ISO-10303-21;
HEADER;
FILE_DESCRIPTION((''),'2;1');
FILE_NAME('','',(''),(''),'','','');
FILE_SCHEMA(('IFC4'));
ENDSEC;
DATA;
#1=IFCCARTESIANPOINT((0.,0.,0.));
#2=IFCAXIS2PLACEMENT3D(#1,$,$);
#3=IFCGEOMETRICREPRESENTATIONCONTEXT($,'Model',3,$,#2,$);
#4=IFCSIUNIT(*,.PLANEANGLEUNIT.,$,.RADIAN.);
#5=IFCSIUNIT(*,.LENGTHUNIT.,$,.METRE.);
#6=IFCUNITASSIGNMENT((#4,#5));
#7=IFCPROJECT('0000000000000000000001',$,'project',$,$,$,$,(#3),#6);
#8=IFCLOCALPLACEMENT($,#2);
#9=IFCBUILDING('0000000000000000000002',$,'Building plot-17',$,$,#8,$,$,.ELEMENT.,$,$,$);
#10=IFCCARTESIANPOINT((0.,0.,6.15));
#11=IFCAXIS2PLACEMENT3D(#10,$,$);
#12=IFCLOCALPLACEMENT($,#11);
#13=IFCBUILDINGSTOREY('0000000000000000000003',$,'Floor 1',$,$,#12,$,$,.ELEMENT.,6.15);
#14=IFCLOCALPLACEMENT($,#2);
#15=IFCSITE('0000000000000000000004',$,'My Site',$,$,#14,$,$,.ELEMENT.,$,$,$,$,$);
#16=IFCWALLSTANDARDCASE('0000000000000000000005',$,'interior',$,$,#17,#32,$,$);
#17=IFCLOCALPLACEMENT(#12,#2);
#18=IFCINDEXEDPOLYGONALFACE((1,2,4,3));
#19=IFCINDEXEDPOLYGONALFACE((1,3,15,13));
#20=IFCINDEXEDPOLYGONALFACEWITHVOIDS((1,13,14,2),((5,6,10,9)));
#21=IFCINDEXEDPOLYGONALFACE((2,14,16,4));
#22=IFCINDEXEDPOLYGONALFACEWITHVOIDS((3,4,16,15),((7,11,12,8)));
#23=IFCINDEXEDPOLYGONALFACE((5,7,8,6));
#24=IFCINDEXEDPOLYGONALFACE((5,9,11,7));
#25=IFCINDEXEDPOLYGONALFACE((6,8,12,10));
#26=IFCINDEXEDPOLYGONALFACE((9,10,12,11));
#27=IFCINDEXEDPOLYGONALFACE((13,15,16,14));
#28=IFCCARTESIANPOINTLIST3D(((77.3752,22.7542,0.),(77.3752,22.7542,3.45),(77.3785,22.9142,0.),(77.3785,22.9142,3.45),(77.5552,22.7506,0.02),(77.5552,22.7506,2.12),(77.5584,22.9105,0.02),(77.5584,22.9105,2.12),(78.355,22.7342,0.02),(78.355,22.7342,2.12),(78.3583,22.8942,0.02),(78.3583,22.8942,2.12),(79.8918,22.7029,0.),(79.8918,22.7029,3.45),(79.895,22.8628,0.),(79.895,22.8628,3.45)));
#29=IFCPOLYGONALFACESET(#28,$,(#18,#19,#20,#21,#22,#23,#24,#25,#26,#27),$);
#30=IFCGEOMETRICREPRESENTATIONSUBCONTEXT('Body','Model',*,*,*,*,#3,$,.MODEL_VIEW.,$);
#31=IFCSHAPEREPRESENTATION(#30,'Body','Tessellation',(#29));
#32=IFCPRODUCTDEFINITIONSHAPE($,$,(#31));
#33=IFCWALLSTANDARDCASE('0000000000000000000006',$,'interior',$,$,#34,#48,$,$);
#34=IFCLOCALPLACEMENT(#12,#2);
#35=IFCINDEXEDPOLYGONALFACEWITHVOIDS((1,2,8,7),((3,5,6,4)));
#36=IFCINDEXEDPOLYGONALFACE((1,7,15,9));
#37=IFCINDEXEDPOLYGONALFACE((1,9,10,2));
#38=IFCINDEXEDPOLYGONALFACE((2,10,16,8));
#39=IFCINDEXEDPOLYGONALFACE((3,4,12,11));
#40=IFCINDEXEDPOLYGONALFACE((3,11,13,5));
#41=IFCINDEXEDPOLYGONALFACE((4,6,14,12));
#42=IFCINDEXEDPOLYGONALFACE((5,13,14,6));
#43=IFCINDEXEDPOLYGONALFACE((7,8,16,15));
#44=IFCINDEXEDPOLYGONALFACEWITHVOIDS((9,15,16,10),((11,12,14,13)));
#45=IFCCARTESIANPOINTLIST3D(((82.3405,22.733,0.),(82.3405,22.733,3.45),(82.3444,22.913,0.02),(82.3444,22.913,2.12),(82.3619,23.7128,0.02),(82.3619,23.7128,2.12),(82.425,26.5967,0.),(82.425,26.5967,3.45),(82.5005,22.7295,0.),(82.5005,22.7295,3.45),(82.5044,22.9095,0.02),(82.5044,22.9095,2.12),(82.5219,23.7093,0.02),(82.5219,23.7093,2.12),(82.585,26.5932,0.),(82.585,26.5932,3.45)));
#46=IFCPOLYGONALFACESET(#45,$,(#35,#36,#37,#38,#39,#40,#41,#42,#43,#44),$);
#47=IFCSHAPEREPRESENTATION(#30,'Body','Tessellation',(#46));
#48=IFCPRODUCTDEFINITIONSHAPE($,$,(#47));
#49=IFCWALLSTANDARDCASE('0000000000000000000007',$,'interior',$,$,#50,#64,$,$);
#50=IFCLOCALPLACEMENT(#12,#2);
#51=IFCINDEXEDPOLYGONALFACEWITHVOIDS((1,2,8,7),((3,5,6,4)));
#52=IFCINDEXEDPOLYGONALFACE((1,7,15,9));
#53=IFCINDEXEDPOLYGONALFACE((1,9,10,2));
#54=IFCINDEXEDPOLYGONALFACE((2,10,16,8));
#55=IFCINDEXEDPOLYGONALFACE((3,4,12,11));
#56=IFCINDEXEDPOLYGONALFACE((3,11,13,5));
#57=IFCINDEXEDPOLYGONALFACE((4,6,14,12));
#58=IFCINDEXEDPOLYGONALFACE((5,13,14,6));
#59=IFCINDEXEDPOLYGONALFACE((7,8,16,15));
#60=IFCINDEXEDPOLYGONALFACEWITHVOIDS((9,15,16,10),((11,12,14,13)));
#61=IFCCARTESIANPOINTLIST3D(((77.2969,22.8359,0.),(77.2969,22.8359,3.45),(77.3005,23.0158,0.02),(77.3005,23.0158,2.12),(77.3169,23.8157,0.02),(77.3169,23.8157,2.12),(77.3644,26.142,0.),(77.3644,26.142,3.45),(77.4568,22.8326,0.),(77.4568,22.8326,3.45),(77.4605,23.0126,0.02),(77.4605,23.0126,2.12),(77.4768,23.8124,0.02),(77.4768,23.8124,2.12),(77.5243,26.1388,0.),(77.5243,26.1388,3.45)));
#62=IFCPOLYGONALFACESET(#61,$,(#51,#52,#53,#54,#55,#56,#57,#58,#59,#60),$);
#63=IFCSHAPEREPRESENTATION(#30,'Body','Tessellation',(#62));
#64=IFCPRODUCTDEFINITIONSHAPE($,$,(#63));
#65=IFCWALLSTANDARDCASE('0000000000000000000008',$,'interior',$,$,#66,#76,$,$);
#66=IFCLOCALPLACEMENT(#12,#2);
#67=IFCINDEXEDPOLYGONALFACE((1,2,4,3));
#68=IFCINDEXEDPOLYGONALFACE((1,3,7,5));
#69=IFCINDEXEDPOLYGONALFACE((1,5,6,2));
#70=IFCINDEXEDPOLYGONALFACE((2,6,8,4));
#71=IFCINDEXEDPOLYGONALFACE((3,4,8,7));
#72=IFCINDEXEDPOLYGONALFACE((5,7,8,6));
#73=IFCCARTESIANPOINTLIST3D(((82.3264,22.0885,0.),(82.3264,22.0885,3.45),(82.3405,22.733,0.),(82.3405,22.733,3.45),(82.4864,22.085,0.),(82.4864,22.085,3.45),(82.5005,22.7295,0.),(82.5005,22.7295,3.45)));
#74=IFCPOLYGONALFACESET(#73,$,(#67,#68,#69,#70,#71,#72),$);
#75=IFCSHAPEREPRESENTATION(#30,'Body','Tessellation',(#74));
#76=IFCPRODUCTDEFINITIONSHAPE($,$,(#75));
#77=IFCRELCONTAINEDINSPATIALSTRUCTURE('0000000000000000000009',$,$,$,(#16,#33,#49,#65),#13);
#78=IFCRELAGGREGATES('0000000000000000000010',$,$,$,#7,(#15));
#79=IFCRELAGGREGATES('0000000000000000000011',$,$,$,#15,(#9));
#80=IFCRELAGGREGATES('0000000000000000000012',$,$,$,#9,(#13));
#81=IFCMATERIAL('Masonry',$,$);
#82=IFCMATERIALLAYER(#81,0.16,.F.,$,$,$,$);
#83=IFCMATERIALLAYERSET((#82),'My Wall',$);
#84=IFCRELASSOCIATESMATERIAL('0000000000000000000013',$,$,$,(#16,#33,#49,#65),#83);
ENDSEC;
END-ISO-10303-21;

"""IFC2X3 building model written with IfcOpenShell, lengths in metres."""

from ifc_helpers import new_model, si_unit, frame, origin, place, context, subcontext, project, spatial, polyline, outline, extrude, material, layer, layer_set, layer_usage, element, save


model = new_model("IFC2X3")

# Units and contexts
model_context = context("Model", 3, world=origin())
body_context = subcontext(model_context, "Body", "Model", "MODEL_VIEW")
ifc_project = project(units=[si_unit("PLANEANGLEUNIT", "RADIAN"), si_unit("LENGTHUNIT", "METRE")], contexts=[model_context])

# Site, building, storey
site_placement = place(None, origin())
site = spatial("IfcSite", under=ifc_project, at=site_placement, Name="My Site", CompositionType="ELEMENT")
building_placement = place(None, origin())
building = spatial("IfcBuilding", under=site, at=building_placement, Name="Building plot-17", CompositionType="ELEMENT")
storey_placement = place(None, frame((0.0, 0.0, 6.15)))
storey = spatial("IfcBuildingStorey", under=building, at=storey_placement, Name="Floor 1", CompositionType="ELEMENT", Elevation=6.15)

# Walls, openings
ifc_material_1 = material(Name="Masonry")
ifc_layer_1 = layer(ifc_material_1, 0.16, ventilated=False)
ifc_layer_set_1 = layer_set([ifc_layer_1], Name="My Wall")
ifc_layer_usage_1 = layer_usage(ifc_layer_set_1, "AXIS2", "NEGATIVE", 0.08)
wall_1_placement = place(storey_placement, origin())
wall_1 = element("IfcWallStandardCase", 1, at=wall_1_placement, inside=storey, material=ifc_layer_usage_1, Name="interior", context=body_context, shape_type="SweptSolid", body=[
    extrude(outline(polyline([(77.3785, 22.9142), (77.3752, 22.7542), (79.8918, 22.7029), (79.895, 22.8628), (77.3785, 22.9142)])), origin(), (0.0, 0.0, 1.0), 3.45),
])
opening_1_placement = place(storey_placement, frame((0.0, 0.0, 0.02)))
element("IfcOpeningElement", 2, at=opening_1_placement, cuts=wall_1, ObjectType="Opening", context=body_context, shape_type="SweptSolid", body=[
    extrude(outline(polyline([(77.5552, 22.7506), (78.355, 22.7342), (78.3583, 22.8942), (77.5584, 22.9105), (77.5552, 22.7506)])), origin(), (0.0, 0.0, 1.0), 2.1),
])
wall_2_placement = place(storey_placement, origin())
wall_2 = element("IfcWallStandardCase", 3, at=wall_2_placement, inside=storey, material=ifc_layer_usage_1, Name="interior", context=body_context, shape_type="SweptSolid", body=[
    extrude(outline(polyline([(82.585, 26.5932), (82.425, 26.5967), (82.3405, 22.733), (82.5005, 22.7295), (82.585, 26.5932)])), origin(), (0.0, 0.0, 1.0), 3.45),
])
opening_2_placement = place(storey_placement, frame((0.0, 0.0, 0.02)))
element("IfcOpeningElement", 4, at=opening_2_placement, cuts=wall_2, ObjectType="Opening", context=body_context, shape_type="SweptSolid", body=[
    extrude(outline(polyline([(82.3619, 23.7128), (82.3444, 22.913), (82.5044, 22.9095), (82.5219, 23.7093), (82.3619, 23.7128)])), origin(), (0.0, 0.0, 1.0), 2.1),
])
wall_3_placement = place(storey_placement, origin())
wall_3 = element("IfcWallStandardCase", 5, at=wall_3_placement, inside=storey, material=ifc_layer_usage_1, Name="interior", context=body_context, shape_type="SweptSolid", body=[
    extrude(outline(polyline([(77.2969, 22.8359), (77.4568, 22.8326), (77.5243, 26.1388), (77.3644, 26.142), (77.2969, 22.8359)])), origin(), (0.0, 0.0, 1.0), 3.45),
])
opening_3_placement = place(storey_placement, frame((0.0, 0.0, 0.02)))
element("IfcOpeningElement", 6, at=opening_3_placement, cuts=wall_3, ObjectType="Opening", context=body_context, shape_type="SweptSolid", body=[
    extrude(outline(polyline([(77.4605, 23.0126), (77.4768, 23.8124), (77.3169, 23.8157), (77.3005, 23.0158), (77.4605, 23.0126)])), origin(), (0.0, 0.0, 1.0), 2.1),
])

# Wall
wall_4_placement = place(storey_placement, origin())
element("IfcWallStandardCase", 7, at=wall_4_placement, inside=storey, material=ifc_layer_usage_1, Name="interior", context=body_context, shape_type="SweptSolid", body=[
    extrude(outline(polyline([(82.5005, 22.7295), (82.3405, 22.733), (82.3264, 22.0885), (82.4864, 22.085), (82.5005, 22.7295)])), origin(), (0.0, 0.0, 1.0), 3.45),
])

save(model, "model.ifc")
